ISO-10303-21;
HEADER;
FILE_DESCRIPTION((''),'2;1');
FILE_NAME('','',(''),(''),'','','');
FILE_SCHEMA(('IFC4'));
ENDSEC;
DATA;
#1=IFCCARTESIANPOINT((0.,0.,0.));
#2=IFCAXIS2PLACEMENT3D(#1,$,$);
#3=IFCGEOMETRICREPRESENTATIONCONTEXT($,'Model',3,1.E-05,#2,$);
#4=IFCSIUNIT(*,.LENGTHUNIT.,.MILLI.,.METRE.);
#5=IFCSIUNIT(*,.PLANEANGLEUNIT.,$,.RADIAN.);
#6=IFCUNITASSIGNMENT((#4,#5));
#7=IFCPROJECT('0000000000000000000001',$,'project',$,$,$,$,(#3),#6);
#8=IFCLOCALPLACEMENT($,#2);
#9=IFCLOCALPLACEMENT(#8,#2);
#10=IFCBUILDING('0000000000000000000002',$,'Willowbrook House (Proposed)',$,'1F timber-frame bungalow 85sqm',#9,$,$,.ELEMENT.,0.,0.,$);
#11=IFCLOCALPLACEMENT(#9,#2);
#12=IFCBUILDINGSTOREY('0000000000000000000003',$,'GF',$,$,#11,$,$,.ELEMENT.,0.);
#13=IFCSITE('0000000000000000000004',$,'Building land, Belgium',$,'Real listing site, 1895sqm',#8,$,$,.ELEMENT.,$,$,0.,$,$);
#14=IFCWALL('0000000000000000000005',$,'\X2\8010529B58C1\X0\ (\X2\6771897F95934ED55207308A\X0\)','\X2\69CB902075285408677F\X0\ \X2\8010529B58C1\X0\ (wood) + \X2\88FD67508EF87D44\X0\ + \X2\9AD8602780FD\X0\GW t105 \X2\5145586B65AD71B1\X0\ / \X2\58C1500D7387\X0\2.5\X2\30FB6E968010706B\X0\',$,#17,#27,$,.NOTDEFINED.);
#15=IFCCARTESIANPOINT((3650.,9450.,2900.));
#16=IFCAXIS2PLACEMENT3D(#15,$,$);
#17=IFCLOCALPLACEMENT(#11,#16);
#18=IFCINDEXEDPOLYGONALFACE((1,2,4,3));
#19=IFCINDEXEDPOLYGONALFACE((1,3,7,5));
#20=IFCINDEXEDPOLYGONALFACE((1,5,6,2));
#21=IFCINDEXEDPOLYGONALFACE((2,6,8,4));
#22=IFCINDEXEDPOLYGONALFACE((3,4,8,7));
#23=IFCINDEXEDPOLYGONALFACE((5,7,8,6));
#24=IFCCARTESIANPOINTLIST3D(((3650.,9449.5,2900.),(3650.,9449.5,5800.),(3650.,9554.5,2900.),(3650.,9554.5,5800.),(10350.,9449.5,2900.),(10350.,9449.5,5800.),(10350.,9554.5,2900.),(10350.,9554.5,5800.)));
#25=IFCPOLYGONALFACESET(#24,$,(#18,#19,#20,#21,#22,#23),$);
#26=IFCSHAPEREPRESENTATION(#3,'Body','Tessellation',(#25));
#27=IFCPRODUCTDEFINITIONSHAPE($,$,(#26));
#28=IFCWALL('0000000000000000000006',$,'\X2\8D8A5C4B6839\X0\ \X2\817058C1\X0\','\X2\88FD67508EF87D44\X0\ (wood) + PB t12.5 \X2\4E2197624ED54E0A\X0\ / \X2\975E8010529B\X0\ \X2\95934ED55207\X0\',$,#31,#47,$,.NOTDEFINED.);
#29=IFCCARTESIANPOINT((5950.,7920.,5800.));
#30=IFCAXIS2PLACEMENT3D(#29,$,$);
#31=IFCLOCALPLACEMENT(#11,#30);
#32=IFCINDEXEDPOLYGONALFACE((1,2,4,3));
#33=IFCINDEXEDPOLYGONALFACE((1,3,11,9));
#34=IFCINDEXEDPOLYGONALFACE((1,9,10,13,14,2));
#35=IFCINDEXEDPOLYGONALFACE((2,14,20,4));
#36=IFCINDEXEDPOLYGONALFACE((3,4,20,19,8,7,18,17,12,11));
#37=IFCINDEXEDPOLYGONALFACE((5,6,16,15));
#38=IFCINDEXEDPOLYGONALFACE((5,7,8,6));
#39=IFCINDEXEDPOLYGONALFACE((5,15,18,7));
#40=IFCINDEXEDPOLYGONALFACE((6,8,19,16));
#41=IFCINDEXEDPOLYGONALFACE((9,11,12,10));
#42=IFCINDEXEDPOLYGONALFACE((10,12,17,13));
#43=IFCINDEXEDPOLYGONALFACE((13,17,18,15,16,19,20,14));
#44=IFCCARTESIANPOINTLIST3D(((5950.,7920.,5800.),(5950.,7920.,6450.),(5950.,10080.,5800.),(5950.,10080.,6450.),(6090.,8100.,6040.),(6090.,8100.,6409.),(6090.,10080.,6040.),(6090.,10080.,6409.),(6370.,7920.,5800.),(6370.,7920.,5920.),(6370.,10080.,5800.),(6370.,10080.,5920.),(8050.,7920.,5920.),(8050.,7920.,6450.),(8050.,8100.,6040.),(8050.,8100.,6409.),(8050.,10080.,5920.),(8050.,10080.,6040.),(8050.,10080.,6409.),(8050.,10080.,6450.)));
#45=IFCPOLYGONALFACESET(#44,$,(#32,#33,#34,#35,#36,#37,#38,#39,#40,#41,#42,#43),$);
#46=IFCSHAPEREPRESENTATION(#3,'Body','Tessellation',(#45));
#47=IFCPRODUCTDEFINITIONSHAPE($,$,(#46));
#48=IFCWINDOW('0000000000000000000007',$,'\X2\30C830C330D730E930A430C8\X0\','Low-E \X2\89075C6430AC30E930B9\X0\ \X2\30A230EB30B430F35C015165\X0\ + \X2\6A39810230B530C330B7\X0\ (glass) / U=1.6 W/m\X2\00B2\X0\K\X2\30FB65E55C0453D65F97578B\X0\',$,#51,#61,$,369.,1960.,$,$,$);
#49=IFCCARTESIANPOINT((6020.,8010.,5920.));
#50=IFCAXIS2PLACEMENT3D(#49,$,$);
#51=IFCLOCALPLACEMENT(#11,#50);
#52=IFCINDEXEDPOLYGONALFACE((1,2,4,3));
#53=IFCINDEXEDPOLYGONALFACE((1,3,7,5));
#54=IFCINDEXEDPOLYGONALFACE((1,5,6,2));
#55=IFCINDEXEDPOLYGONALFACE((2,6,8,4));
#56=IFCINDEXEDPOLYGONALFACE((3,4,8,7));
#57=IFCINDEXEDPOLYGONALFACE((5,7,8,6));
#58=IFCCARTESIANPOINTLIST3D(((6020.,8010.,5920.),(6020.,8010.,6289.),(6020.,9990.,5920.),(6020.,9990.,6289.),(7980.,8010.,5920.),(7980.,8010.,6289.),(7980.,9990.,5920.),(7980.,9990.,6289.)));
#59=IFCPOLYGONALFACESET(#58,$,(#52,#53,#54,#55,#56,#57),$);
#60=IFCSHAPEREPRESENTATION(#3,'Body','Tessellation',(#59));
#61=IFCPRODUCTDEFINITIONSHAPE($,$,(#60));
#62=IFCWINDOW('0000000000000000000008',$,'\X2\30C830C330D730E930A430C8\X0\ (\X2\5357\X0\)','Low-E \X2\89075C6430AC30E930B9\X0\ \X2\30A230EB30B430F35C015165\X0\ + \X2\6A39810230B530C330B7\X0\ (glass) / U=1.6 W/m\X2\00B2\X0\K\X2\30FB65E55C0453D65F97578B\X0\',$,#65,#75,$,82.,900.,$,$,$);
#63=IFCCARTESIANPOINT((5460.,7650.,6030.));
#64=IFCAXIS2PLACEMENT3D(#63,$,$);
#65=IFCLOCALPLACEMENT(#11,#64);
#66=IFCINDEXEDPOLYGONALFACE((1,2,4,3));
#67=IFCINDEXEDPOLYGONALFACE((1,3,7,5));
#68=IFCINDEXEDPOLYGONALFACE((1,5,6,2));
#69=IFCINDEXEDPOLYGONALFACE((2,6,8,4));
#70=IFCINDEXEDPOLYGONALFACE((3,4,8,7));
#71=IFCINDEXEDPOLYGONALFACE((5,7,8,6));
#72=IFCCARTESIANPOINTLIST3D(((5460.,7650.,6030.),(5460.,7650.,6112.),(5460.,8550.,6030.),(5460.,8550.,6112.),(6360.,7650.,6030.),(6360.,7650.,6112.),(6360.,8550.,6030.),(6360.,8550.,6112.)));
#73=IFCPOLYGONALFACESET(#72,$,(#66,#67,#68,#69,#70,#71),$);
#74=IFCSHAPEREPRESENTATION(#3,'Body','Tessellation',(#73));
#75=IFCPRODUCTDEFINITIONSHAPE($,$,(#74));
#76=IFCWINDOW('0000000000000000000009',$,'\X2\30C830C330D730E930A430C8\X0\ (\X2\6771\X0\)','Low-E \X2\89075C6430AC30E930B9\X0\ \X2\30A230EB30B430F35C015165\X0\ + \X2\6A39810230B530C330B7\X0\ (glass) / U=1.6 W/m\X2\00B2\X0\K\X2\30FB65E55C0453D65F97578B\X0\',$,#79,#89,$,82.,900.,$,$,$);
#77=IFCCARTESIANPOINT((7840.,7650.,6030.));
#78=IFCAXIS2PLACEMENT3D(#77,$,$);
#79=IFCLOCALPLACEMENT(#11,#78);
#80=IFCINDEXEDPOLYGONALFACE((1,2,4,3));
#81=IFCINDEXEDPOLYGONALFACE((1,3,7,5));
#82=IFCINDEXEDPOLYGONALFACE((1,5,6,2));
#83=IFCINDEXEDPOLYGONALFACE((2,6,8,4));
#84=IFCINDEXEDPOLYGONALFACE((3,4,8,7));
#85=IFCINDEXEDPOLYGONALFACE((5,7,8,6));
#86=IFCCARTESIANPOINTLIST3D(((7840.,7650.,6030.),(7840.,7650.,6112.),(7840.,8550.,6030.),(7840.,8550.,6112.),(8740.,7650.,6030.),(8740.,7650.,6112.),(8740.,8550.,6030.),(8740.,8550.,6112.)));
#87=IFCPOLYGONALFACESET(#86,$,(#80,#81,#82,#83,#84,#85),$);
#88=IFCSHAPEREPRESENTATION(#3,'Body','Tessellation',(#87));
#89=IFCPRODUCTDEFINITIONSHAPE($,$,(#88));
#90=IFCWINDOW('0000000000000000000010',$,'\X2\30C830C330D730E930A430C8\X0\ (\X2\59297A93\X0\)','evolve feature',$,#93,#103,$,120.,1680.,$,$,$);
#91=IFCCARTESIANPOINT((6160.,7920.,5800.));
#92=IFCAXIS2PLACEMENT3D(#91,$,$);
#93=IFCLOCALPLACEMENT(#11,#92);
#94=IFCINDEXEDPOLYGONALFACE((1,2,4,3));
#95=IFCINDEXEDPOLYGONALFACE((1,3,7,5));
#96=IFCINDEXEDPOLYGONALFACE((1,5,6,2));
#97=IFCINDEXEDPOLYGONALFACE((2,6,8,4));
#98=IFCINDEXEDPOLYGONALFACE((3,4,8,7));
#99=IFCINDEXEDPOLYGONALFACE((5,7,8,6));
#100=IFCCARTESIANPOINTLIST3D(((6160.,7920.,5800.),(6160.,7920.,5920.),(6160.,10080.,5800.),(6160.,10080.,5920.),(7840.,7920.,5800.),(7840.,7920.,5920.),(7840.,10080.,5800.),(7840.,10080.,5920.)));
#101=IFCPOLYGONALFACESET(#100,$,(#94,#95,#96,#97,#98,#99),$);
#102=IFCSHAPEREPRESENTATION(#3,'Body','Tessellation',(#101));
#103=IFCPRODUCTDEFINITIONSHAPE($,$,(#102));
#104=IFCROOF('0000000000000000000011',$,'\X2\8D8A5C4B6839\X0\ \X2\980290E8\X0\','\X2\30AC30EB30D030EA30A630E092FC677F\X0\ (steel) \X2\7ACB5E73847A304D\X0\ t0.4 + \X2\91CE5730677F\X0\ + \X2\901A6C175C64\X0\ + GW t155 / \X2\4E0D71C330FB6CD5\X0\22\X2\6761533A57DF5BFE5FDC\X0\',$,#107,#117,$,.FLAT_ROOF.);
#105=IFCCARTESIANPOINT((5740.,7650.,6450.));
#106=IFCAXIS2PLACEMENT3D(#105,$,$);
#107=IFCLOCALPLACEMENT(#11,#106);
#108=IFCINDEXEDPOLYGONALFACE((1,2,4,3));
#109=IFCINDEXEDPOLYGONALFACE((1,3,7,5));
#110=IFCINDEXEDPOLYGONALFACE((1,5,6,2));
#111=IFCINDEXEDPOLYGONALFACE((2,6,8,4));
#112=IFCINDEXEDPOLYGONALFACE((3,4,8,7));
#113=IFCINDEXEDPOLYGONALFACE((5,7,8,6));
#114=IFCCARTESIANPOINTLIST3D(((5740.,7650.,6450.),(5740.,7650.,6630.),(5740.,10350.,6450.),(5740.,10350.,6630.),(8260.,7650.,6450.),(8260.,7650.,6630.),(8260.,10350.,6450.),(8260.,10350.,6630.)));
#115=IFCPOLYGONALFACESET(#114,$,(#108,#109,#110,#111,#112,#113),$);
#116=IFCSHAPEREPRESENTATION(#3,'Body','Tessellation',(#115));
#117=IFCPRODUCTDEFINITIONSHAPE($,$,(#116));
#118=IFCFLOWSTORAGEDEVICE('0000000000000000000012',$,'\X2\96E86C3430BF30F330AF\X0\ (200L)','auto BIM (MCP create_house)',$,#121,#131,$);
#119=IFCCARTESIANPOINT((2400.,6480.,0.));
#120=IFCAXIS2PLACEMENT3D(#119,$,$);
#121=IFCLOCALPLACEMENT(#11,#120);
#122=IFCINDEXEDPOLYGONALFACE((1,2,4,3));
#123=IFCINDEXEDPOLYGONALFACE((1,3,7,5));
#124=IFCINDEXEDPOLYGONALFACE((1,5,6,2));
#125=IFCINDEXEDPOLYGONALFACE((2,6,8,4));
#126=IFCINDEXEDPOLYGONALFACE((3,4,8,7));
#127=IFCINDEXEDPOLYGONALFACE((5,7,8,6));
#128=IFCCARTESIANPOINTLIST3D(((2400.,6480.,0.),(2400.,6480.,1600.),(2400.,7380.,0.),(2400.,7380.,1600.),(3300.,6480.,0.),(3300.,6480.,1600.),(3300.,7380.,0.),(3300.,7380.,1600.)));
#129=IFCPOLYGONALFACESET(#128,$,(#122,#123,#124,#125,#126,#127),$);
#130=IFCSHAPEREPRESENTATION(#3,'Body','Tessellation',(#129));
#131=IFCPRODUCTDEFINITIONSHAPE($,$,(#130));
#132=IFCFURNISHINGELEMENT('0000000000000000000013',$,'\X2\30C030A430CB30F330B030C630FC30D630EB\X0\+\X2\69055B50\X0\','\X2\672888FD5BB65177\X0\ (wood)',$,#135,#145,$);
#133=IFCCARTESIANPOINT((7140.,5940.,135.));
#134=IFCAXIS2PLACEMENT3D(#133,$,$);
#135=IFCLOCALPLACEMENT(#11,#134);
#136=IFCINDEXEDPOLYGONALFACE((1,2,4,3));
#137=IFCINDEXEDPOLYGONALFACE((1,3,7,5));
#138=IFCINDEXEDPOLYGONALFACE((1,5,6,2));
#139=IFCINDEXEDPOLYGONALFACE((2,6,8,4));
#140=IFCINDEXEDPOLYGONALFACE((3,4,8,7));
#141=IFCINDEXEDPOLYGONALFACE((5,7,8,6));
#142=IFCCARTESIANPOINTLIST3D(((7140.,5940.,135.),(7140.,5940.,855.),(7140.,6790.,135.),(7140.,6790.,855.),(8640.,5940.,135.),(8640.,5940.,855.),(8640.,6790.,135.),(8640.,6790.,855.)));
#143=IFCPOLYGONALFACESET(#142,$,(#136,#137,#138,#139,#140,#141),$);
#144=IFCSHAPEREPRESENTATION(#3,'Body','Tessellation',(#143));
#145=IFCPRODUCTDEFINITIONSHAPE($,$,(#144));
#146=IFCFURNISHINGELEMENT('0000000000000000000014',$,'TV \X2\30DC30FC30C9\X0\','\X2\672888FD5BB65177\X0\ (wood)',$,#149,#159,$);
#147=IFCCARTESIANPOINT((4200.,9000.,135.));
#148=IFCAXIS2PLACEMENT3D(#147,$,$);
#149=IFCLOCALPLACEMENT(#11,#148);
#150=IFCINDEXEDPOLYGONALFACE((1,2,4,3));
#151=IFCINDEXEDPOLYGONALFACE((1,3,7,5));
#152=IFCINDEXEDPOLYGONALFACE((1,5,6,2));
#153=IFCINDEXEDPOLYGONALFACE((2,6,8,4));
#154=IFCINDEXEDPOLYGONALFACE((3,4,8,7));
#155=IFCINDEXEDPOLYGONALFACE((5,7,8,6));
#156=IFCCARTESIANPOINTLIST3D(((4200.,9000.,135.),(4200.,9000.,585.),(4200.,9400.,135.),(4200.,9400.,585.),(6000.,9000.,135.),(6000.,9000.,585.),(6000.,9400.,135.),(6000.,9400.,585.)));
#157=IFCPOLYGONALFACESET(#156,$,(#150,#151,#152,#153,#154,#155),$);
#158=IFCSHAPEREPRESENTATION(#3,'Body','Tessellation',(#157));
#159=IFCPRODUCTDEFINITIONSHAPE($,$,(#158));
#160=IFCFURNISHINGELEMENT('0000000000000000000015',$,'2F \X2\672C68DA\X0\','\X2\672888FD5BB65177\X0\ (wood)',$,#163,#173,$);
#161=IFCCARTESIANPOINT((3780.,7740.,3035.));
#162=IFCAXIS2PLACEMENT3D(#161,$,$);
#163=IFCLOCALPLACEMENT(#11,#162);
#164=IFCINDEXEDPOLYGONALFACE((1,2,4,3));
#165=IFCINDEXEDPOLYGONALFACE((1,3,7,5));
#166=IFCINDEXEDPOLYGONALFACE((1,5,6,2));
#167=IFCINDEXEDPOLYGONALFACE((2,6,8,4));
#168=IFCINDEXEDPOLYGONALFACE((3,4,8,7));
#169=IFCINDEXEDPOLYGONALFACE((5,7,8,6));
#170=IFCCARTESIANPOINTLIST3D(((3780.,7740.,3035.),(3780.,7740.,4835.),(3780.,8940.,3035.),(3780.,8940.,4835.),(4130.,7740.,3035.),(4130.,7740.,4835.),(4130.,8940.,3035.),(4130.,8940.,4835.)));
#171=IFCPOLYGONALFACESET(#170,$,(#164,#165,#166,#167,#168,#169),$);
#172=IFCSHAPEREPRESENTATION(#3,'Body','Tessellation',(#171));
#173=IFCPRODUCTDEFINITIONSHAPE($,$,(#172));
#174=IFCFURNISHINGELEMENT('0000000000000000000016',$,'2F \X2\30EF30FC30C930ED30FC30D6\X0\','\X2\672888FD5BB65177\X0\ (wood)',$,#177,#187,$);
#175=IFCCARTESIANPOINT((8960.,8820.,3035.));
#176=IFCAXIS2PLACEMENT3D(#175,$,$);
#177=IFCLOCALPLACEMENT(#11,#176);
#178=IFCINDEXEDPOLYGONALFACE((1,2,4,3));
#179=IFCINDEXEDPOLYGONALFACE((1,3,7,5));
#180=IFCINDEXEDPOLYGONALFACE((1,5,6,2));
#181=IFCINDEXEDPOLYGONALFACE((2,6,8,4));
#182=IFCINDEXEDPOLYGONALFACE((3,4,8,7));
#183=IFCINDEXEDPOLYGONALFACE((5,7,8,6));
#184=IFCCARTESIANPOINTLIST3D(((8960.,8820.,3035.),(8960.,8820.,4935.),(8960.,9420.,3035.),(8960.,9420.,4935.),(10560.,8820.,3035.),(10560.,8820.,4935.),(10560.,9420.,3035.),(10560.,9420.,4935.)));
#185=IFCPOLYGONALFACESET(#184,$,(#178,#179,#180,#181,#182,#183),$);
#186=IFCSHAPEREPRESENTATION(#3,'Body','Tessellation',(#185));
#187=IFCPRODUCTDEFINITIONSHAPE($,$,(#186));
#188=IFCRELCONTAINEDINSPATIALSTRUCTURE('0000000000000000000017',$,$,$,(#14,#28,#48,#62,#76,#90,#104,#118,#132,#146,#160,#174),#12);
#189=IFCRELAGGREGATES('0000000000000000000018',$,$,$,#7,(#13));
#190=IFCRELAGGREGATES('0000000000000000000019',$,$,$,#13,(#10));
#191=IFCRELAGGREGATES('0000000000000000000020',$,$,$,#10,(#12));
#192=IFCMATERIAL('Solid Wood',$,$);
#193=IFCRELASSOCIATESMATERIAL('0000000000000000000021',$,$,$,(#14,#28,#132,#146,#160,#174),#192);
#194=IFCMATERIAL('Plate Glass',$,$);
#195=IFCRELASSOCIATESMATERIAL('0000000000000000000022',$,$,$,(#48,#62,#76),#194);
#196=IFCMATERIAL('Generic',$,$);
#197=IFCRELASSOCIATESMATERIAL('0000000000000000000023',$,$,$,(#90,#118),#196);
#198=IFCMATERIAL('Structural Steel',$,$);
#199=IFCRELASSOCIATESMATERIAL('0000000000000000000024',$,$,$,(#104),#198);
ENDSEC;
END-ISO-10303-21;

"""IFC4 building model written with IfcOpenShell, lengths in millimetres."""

from ifc_helpers import new_model, si_unit, frame, frame_2d, origin, place, context, project, spatial, rectangle, extrude, material, element, fill, save


model = new_model("IFC4")

# Units and contexts
model_context = context("Model", 3, precision=1e-05, world=origin())
ifc_project = project(units=[si_unit("LENGTHUNIT", "METRE", prefix="MILLI"), si_unit("PLANEANGLEUNIT", "RADIAN")], contexts=[model_context])

# Site, building, storey
site_placement = place(None, origin())
site = spatial("IfcSite", under=ifc_project, at=site_placement, Name="Building land, Belgium", ObjectType="Real listing site, 1895sqm", CompositionType="ELEMENT", RefElevation=0.0)
building_placement = place(site_placement, origin())
building = spatial("IfcBuilding", under=site, at=building_placement, Name="Willowbrook House (Proposed)", ObjectType="1F timber-frame bungalow 85sqm", CompositionType="ELEMENT", ElevationOfRefHeight=0.0, ElevationOfTerrain=0.0)
storey_placement = place(building_placement, origin())
storey = spatial("IfcBuildingStorey", under=building, at=storey_placement, Name="GF", CompositionType="ELEMENT", Elevation=0.0)

# Wall
ifc_material_1 = material(Name="Solid Wood")
wall_1_placement = place(storey_placement, frame((3650.0, 9450.0, 2900.0)))
element("IfcWall", 1, at=wall_1_placement, inside=storey, material=ifc_material_1, Name="耐力壁 (東西間仕切り)", Description="構造用合板 耐力壁 (wood) + 製材軸組 + 高性能GW t105 充填断熱 / 壁倍率2.5・準耐火", PredefinedType="NOTDEFINED", context=model_context, shape_type="SweptSolid", body=[
    extrude(rectangle(XDim=6700.0, YDim=105.0, at=frame_2d((3350.0, 52.0))), frame((3650.0, 9450.0, 2900.0)), (0.0, 0.0, 1.0), 2900.0),
])

# Wall, openings, windows
wall_2_placement = place(storey_placement, frame((5950.0, 7920.0, 5800.0)))
wall_2 = element("IfcWall", 2, at=wall_2_placement, inside=storey, material=ifc_material_1, Name="越屋根 腰壁", Description="製材軸組 (wood) + PB t12.5 両面仕上 / 非耐力 間仕切", PredefinedType="NOTDEFINED", context=model_context, shape_type="SweptSolid", body=[
    extrude(rectangle(XDim=2100.0, YDim=2160.0, at=frame_2d((1050.0, 1080.0))), frame((5950.0, 7920.0, 5800.0)), (0.0, 0.0, 1.0), 650.0),
])
opening_1_placement = place(storey_placement, frame((6020.0, 8010.0, 5920.0)))
opening_1 = element("IfcOpeningElement", 3, at=opening_1_placement, cuts=wall_2, PredefinedType="NOTDEFINED", context=model_context, shape_type="SweptSolid", body=[
    extrude(rectangle(XDim=1960.0, YDim=1980.0, at=frame_2d((980.0, 990.0))), frame((6020.0, 8010.0, 5920.0)), (0.0, 0.0, 1.0), 369.0),
])
opening_2_placement = place(storey_placement, frame((5460.0, 7650.0, 6030.0)))
opening_2 = element("IfcOpeningElement", 4, at=opening_2_placement, cuts=wall_2, PredefinedType="NOTDEFINED", context=model_context, shape_type="SweptSolid", body=[
    extrude(rectangle(XDim=900.0, YDim=900.0, at=frame_2d((450.0, 450.0))), frame((5460.0, 7650.0, 6030.0)), (0.0, 0.0, 1.0), 82.0),
])
opening_3_placement = place(storey_placement, frame((7840.0, 7650.0, 6030.0)))
opening_3 = element("IfcOpeningElement", 5, at=opening_3_placement, cuts=wall_2, PredefinedType="NOTDEFINED", context=model_context, shape_type="SweptSolid", body=[
    extrude(rectangle(XDim=900.0, YDim=900.0, at=frame_2d((450.0, 450.0))), frame((7840.0, 7650.0, 6030.0)), (0.0, 0.0, 1.0), 82.0),
])
opening_4_placement = place(storey_placement, frame((6160.0, 7920.0, 5800.0)))
opening_4 = element("IfcOpeningElement", 6, at=opening_4_placement, cuts=wall_2, PredefinedType="NOTDEFINED", context=model_context, shape_type="SweptSolid", body=[
    extrude(rectangle(XDim=1680.0, YDim=2160.0, at=frame_2d((840.0, 1080.0))), frame((6160.0, 7920.0, 5800.0)), (0.0, 0.0, 1.0), 120.0),
])
ifc_material_2 = material(Name="Plate Glass")
window_1_placement = place(storey_placement, frame((6020.0, 8010.0, 5920.0)))
window_1 = element("IfcWindow", 7, at=window_1_placement, inside=storey, material=ifc_material_2, Name="トップライト", Description="Low-E 複層ガラス アルゴン封入 + 樹脂サッシ (glass) / U=1.6 W/m²K・日射取得型", OverallHeight=369.0, OverallWidth=1960.0, context=model_context, shape_type="SweptSolid", body=[
    extrude(rectangle(XDim=1960.0, YDim=1980.0, at=frame_2d((980.0, 990.0))), frame((6020.0, 8010.0, 5920.0)), (0.0, 0.0, 1.0), 369.0),
])
fill(opening_1, window_1)
window_2_placement = place(storey_placement, frame((5460.0, 7650.0, 6030.0)))
window_2 = element("IfcWindow", 8, at=window_2_placement, inside=storey, material=ifc_material_2, Name="トップライト (南)", Description="Low-E 複層ガラス アルゴン封入 + 樹脂サッシ (glass) / U=1.6 W/m²K・日射取得型", OverallHeight=82.0, OverallWidth=900.0, context=model_context, shape_type="SweptSolid", body=[
    extrude(rectangle(XDim=900.0, YDim=900.0, at=frame_2d((450.0, 450.0))), frame((5460.0, 7650.0, 6030.0)), (0.0, 0.0, 1.0), 82.0),
])
fill(opening_2, window_2)
window_3_placement = place(storey_placement, frame((7840.0, 7650.0, 6030.0)))
window_3 = element("IfcWindow", 9, at=window_3_placement, inside=storey, material=ifc_material_2, Name="トップライト (東)", Description="Low-E 複層ガラス アルゴン封入 + 樹脂サッシ (glass) / U=1.6 W/m²K・日射取得型", OverallHeight=82.0, OverallWidth=900.0, context=model_context, shape_type="SweptSolid", body=[
    extrude(rectangle(XDim=900.0, YDim=900.0, at=frame_2d((450.0, 450.0))), frame((7840.0, 7650.0, 6030.0)), (0.0, 0.0, 1.0), 82.0),
])
fill(opening_3, window_3)
ifc_material_3 = material(Name="Generic")
window_4_placement = place(storey_placement, frame((6160.0, 7920.0, 5800.0)))
window_4 = element("IfcWindow", 10, at=window_4_placement, inside=storey, material=ifc_material_3, Name="トップライト (天窓)", Description="evolve feature", OverallHeight=120.0, OverallWidth=1680.0, context=model_context, shape_type="SweptSolid", body=[
    extrude(rectangle(XDim=1680.0, YDim=2160.0, at=frame_2d((840.0, 1080.0))), frame((6160.0, 7920.0, 5800.0)), (0.0, 0.0, 1.0), 120.0),
])
fill(opening_4, window_4)

# Roof
ifc_material_4 = material(Name="Structural Steel")
roof_placement = place(storey_placement, frame((5740.0, 7650.0, 6450.0)))
element("IfcRoof", 11, at=roof_placement, inside=storey, material=ifc_material_4, Name="越屋根 頂部", Description="ガルバリウム鋼板 (steel) 立平葺き t0.4 + 野地板 + 通気層 + GW t155 / 不燃・法22条区域対応", PredefinedType="FLAT_ROOF", context=model_context, shape_type="SweptSolid", body=[
    extrude(rectangle(XDim=2520.0, YDim=2700.0, at=frame_2d((1260.0, 1350.0))), frame((5740.0, 7650.0, 6450.0)), (0.0, 0.0, 1.0), 180.0),
])

# Flow storage device
flow_storage_device_placement = place(storey_placement, frame((2400.0, 6480.0, 0.0)))
element("IfcFlowStorageDevice", 12, at=flow_storage_device_placement, inside=storey, material=ifc_material_3, Name="雨水タンク (200L)", Description="auto BIM (MCP create_house)", context=model_context, shape_type="SweptSolid", body=[
    extrude(rectangle(XDim=900.0, YDim=900.0, at=frame_2d((450.0, 450.0))), frame((2400.0, 6480.0, 0.0)), (0.0, 0.0, 1.0), 1600.0),
])

# Furnishing elements
furnishing_1_placement = place(storey_placement, frame((7140.0, 5940.0, 135.0)))
element("IfcFurnishingElement", 13, at=furnishing_1_placement, inside=storey, material=ifc_material_1, Name="ダイニングテーブル+椅子", Description="木製家具 (wood)", context=model_context, shape_type="SweptSolid", body=[
    extrude(rectangle(XDim=1500.0, YDim=850.0, at=frame_2d((750.0, 425.0))), frame((7140.0, 5940.0, 135.0)), (0.0, 0.0, 1.0), 720.0),
])
furnishing_2_placement = place(storey_placement, frame((4200.0, 9000.0, 135.0)))
element("IfcFurnishingElement", 14, at=furnishing_2_placement, inside=storey, material=ifc_material_1, Name="TV ボード", Description="木製家具 (wood)", context=model_context, shape_type="SweptSolid", body=[
    extrude(rectangle(XDim=1800.0, YDim=400.0, at=frame_2d((900.0, 200.0))), frame((4200.0, 9000.0, 135.0)), (0.0, 0.0, 1.0), 450.0),
])
furnishing_3_placement = place(storey_placement, frame((3780.0, 7740.0, 3035.0)))
element("IfcFurnishingElement", 15, at=furnishing_3_placement, inside=storey, material=ifc_material_1, Name="2F 本棚", Description="木製家具 (wood)", context=model_context, shape_type="SweptSolid", body=[
    extrude(rectangle(XDim=350.0, YDim=1200.0, at=frame_2d((175.0, 600.0))), frame((3780.0, 7740.0, 3035.0)), (0.0, 0.0, 1.0), 1800.0),
])
furnishing_4_placement = place(storey_placement, frame((8960.0, 8820.0, 3035.0)))
element("IfcFurnishingElement", 16, at=furnishing_4_placement, inside=storey, material=ifc_material_1, Name="2F ワードローブ", Description="木製家具 (wood)", context=model_context, shape_type="SweptSolid", body=[
    extrude(rectangle(XDim=1600.0, YDim=600.0, at=frame_2d((800.0, 300.0))), frame((8960.0, 8820.0, 3035.0)), (0.0, 0.0, 1.0), 1900.0),
])

save(model, "model.ifc")
